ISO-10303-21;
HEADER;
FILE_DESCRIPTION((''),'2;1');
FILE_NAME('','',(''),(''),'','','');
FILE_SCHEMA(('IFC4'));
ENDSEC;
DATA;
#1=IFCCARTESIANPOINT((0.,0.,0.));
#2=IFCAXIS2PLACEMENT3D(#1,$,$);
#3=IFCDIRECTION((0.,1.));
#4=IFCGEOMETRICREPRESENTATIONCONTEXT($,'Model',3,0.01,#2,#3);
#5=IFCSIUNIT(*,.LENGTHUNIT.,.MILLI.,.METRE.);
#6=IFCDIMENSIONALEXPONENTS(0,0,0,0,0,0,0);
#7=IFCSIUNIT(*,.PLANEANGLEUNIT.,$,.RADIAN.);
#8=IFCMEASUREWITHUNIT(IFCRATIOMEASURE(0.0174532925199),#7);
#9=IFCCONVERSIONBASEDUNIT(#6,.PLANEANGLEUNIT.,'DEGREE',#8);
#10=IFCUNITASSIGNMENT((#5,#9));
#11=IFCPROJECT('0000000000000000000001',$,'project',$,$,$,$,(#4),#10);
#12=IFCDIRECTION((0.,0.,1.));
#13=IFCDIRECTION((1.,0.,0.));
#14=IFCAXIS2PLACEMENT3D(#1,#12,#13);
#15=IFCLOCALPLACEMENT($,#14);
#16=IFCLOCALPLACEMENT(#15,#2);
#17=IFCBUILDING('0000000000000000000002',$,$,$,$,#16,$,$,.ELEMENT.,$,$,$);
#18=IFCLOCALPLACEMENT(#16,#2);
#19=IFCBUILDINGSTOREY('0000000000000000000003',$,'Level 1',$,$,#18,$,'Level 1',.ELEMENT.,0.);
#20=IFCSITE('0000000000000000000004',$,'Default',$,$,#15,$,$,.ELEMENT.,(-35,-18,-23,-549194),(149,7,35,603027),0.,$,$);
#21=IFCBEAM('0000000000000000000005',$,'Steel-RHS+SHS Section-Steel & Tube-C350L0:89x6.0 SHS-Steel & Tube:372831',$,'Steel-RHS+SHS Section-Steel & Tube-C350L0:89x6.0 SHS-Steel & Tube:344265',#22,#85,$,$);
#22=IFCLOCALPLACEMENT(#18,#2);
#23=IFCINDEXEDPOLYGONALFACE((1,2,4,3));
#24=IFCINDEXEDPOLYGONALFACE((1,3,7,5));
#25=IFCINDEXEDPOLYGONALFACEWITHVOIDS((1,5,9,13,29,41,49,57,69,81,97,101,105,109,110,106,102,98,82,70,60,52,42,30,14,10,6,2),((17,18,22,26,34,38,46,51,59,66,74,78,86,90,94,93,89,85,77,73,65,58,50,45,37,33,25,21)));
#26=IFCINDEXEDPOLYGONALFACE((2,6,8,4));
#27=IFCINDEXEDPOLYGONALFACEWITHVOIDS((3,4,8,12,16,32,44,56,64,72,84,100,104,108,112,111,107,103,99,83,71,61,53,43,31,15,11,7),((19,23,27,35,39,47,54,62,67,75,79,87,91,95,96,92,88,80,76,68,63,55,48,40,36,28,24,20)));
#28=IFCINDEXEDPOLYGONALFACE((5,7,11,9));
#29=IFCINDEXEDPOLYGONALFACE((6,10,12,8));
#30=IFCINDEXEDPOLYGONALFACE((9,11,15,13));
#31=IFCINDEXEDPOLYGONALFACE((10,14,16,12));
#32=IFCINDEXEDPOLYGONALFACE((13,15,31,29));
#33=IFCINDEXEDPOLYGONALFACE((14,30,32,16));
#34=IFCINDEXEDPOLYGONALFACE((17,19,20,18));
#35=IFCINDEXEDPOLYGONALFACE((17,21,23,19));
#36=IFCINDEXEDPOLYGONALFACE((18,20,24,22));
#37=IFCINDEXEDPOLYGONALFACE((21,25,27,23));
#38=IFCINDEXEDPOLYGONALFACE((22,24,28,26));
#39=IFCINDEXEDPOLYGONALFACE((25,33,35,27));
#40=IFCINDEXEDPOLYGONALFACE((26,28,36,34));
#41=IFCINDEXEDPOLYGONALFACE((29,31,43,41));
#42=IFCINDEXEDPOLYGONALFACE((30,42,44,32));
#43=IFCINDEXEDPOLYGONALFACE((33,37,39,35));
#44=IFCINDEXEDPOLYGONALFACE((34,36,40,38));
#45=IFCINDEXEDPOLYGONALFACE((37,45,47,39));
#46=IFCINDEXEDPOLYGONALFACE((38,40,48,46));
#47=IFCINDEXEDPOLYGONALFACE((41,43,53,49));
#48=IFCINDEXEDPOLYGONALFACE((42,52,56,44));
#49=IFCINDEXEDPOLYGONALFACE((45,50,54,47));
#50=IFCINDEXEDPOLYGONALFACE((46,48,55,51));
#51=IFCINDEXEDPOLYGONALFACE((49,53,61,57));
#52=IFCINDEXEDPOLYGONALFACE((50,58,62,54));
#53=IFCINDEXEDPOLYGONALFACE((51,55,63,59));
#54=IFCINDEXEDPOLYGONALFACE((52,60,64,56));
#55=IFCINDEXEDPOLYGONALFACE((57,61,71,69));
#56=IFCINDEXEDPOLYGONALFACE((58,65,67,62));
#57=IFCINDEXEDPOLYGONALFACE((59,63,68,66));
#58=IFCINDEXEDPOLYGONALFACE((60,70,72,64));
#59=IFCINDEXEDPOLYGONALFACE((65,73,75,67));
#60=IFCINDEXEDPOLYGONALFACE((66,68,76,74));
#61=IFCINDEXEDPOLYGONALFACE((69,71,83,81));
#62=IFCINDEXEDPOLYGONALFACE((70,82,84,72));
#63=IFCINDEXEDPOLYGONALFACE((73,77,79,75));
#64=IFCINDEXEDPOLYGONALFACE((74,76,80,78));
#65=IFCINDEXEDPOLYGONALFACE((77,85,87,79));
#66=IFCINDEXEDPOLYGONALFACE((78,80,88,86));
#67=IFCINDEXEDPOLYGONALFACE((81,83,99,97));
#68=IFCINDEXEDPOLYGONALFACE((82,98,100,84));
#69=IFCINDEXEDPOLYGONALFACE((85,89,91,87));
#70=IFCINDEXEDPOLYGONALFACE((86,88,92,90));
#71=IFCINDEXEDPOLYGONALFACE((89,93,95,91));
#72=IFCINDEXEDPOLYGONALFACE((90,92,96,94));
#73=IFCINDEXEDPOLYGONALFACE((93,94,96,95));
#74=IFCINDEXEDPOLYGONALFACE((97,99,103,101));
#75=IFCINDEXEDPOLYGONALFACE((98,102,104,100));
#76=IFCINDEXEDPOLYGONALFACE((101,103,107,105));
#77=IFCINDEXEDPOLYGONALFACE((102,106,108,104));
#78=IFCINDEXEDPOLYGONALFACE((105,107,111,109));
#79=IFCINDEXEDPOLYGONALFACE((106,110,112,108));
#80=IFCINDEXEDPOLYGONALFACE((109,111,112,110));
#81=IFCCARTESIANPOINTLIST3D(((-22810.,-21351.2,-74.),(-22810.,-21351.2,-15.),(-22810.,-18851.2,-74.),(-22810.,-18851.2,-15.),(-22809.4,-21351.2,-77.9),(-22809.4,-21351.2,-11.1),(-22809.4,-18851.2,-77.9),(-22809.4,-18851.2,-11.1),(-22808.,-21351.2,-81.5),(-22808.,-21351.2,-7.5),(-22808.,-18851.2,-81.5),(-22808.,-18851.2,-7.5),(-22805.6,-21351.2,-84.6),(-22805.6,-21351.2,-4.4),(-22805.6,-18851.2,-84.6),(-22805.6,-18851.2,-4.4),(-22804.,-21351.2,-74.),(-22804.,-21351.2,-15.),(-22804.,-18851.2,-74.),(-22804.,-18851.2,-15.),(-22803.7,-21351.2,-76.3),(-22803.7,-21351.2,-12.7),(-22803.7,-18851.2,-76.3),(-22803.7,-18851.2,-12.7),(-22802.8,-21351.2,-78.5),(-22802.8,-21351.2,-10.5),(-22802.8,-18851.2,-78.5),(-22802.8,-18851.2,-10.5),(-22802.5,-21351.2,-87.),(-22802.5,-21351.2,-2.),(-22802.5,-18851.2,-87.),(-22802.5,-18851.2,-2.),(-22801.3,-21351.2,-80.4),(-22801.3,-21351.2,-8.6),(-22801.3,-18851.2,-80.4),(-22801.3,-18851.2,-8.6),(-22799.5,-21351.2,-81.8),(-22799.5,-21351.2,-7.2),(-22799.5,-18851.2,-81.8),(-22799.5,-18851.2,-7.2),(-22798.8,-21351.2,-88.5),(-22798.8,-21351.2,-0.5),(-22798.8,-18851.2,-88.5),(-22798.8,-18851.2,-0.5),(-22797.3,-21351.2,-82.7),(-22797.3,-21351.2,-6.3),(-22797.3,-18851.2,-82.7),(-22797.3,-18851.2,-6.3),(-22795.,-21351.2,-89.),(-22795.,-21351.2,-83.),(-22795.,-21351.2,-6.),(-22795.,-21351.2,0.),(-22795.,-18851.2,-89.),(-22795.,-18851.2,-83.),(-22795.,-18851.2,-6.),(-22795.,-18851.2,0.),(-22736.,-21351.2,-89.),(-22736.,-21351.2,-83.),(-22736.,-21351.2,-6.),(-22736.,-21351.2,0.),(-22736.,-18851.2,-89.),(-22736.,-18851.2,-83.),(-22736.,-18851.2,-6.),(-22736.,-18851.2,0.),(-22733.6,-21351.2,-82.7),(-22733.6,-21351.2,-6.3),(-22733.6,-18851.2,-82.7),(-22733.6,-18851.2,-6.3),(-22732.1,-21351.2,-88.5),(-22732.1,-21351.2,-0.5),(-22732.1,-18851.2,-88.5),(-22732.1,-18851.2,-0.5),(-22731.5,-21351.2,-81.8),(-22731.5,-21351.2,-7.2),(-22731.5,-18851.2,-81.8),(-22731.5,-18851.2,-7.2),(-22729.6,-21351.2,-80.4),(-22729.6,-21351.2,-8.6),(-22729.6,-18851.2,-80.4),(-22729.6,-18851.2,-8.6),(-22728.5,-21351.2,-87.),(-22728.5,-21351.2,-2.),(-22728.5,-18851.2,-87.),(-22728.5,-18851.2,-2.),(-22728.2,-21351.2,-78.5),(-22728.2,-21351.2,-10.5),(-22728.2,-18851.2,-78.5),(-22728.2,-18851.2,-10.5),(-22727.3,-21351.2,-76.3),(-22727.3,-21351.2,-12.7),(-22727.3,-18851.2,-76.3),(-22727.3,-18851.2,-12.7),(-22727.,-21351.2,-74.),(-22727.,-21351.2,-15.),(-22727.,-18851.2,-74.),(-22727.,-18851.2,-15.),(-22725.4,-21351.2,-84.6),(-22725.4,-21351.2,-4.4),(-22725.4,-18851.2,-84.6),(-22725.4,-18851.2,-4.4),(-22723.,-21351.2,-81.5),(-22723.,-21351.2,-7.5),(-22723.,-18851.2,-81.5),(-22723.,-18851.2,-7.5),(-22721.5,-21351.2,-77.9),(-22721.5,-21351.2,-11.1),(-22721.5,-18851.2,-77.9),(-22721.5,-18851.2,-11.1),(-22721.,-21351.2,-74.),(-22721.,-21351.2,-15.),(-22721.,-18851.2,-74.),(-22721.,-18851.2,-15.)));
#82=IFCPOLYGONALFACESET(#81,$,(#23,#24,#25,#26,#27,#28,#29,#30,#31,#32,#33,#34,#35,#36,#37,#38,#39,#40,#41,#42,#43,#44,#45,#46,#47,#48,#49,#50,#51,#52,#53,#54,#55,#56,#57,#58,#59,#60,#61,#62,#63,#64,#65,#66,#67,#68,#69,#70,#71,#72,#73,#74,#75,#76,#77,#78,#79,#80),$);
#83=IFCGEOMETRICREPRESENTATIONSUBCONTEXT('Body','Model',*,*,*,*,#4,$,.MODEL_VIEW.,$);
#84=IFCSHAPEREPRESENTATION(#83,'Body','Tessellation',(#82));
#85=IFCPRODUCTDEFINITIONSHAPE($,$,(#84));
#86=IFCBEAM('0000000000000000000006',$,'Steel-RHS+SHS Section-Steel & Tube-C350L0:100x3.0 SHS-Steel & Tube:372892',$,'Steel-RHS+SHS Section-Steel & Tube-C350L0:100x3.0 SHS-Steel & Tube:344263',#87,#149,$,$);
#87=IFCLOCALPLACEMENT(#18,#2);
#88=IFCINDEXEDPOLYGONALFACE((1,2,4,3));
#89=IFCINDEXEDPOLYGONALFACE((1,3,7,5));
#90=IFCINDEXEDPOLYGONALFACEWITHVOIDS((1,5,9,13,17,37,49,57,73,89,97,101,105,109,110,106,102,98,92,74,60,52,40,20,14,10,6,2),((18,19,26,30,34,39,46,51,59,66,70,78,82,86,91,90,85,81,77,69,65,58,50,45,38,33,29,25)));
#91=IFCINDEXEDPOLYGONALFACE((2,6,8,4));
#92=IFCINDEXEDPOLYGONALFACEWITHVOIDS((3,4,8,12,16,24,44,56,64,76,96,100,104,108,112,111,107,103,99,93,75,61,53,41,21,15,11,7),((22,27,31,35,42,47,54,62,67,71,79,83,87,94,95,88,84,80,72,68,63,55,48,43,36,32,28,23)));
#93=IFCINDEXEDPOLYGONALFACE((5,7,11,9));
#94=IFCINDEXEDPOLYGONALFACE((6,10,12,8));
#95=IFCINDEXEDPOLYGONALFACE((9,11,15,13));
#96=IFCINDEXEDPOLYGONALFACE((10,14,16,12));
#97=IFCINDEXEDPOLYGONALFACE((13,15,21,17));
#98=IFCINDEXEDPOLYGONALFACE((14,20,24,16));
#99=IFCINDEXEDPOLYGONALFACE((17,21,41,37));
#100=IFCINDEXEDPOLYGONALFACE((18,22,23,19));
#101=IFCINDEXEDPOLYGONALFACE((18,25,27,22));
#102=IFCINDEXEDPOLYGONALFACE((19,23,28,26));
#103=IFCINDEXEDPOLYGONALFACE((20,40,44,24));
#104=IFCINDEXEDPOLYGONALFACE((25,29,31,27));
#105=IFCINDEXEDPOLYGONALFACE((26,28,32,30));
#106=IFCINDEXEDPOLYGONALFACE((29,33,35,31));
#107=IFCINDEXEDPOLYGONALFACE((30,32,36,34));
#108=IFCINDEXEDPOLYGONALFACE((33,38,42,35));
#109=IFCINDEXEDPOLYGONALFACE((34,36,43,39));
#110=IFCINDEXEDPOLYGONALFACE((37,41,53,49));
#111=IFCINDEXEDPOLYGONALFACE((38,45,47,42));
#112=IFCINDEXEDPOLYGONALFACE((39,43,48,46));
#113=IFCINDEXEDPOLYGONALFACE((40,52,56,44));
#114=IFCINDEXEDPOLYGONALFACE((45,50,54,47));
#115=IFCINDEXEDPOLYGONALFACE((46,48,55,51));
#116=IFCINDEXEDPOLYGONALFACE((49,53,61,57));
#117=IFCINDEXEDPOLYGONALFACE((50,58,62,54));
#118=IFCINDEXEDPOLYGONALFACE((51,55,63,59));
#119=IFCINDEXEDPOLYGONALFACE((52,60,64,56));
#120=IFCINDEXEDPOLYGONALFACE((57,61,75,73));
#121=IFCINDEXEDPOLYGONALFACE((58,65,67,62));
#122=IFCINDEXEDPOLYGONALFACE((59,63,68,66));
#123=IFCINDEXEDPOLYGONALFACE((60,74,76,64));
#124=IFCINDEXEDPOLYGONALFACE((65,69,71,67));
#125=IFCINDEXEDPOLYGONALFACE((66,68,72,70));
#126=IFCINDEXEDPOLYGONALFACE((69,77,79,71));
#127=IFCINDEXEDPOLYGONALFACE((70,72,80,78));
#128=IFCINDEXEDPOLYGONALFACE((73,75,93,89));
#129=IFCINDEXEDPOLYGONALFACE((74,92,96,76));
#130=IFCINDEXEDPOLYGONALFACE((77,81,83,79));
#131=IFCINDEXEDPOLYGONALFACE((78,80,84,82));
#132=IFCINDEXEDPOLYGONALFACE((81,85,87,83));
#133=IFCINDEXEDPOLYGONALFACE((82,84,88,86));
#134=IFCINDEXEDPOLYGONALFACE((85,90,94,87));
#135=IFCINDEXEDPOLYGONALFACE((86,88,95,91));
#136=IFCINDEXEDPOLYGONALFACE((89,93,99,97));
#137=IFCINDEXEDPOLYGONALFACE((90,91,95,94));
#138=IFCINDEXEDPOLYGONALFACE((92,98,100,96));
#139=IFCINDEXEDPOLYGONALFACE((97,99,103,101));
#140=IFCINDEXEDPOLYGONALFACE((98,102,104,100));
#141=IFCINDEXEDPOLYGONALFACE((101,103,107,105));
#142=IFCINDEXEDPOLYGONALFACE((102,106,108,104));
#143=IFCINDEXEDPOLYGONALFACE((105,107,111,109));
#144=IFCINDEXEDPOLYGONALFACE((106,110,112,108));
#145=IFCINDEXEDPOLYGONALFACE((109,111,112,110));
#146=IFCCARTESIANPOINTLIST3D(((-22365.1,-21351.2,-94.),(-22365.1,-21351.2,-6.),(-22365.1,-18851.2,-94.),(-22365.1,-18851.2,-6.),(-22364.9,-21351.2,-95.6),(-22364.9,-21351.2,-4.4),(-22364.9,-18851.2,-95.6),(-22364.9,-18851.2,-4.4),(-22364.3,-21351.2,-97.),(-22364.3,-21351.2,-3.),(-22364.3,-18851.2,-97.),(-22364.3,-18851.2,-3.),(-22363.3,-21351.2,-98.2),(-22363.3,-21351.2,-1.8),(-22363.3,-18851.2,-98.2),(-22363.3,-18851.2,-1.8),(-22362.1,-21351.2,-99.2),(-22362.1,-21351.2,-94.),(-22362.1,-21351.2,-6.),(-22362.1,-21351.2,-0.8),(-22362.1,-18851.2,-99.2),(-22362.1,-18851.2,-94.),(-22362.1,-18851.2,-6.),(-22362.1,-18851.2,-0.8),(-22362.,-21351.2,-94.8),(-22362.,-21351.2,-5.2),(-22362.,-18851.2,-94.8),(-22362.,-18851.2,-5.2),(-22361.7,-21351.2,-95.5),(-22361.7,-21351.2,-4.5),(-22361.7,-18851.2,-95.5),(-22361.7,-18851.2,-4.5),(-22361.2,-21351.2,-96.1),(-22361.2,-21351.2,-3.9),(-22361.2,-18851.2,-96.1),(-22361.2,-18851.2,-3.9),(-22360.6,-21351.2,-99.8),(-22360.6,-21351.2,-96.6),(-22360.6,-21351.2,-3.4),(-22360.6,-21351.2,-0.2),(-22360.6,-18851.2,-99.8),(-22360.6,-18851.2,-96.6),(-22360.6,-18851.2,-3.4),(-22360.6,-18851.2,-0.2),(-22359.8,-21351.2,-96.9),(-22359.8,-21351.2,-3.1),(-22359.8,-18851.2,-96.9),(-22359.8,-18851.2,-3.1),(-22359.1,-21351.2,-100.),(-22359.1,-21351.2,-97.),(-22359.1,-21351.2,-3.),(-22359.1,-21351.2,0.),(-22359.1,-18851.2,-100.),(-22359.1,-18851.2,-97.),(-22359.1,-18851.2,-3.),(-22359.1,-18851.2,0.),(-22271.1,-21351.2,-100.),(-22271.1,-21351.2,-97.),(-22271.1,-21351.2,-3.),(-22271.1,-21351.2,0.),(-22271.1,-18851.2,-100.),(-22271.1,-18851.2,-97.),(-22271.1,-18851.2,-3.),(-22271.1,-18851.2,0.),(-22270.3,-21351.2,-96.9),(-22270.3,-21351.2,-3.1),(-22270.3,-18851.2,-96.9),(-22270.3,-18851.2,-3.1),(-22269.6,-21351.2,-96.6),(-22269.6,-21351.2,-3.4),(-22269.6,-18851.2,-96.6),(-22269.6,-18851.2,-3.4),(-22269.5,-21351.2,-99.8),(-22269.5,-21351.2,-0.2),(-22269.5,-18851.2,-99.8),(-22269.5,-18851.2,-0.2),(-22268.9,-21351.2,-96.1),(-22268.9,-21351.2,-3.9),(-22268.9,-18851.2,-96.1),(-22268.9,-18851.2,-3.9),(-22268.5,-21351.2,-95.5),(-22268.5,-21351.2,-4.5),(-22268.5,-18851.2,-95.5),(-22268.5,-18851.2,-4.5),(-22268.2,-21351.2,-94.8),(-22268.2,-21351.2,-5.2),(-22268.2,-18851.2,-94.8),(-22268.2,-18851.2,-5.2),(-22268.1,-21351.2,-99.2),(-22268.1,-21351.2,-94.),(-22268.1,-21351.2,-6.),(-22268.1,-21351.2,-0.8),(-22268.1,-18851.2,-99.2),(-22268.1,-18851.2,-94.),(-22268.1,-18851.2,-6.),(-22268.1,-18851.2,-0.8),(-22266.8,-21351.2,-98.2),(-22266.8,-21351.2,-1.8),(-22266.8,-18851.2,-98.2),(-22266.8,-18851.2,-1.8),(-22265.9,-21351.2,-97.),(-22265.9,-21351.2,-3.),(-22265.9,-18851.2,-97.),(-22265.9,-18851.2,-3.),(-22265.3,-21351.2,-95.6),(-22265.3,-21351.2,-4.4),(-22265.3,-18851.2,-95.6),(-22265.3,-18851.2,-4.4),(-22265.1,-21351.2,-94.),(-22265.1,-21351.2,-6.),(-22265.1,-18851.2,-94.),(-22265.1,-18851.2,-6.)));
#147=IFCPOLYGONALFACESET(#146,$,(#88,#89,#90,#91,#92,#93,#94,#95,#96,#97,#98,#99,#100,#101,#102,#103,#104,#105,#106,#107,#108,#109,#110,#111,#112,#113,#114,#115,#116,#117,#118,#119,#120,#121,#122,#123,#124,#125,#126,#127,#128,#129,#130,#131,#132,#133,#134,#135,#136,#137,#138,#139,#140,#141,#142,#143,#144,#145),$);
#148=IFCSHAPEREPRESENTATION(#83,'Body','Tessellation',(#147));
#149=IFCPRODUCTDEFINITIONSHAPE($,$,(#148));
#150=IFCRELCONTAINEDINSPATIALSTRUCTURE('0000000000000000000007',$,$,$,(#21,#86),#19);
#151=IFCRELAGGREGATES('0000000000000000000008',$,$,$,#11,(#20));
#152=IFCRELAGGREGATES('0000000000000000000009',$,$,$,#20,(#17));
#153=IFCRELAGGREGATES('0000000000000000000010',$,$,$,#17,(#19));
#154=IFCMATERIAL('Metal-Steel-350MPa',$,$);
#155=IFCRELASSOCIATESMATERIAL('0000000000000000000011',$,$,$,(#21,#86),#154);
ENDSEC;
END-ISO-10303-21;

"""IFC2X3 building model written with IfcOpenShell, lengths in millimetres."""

from ifc_helpers import new_model, entity, si_unit, converted_unit, direction, frame, frame_2d, origin, origin_with_axes, place, context, subcontext, project, spatial, polyline, circle_curve, parameter, trimmed, segment, composite_curve, outline, extrude, material, element, save


model = new_model("IFC2X3")

# Units and contexts
model_context = context("Model", 3, precision=0.01, world=origin(), true_north=direction((0.0, 1.0)))
body_context = subcontext(model_context, "Body", "Model", "MODEL_VIEW")
ifc_project = project(units=[si_unit("LENGTHUNIT", "METRE", prefix="MILLI"), converted_unit("PLANEANGLEUNIT", "DEGREE", entity("IfcRatioMeasure", 0.0174532925199), si_unit("PLANEANGLEUNIT", "RADIAN"), dimensions=[0, 0, 0, 0, 0, 0, 0])], contexts=[model_context])

# Site, building, storey
site_placement = place(None, origin_with_axes())
site = spatial("IfcSite", under=ifc_project, at=site_placement, Name="Default", CompositionType="ELEMENT", RefLatitude=(-35, -18, -23, -549194), RefLongitude=(149, 7, 35, 603027), RefElevation=0.0)
building_placement = place(site_placement, origin())
building = spatial("IfcBuilding", under=site, at=building_placement, CompositionType="ELEMENT")
storey_placement = place(building_placement, origin())
storey = spatial("IfcBuildingStorey", under=building, at=storey_placement, Name="Level 1", LongName="Level 1", CompositionType="ELEMENT", Elevation=0.0)

# Beams
ifc_material = material(Name="Metal-Steel-350MPa")
beam_1_placement = place(storey_placement, frame((-22765.5, -18851.2, 0.0), z_axis=(0.0, 0.0, 1.0), x_axis=(0.0, -1.0, 0.0)))
element("IfcBeam", 1, at=beam_1_placement, inside=storey, material=ifc_material, Name="Steel-RHS+SHS Section-Steel & Tube-C350L0:89x6.0 SHS-Steel & Tube:372831", ObjectType="Steel-RHS+SHS Section-Steel & Tube-C350L0:89x6.0 SHS-Steel & Tube:344265", context=body_context, shape_type="SweptSolid", body=[
    extrude(outline(composite_curve([segment(trimmed(circle_curve(frame_2d((-29.5, -29.5), x_axis=(1.0, 0.0)), 15.0), [parameter(180.0)], [parameter(270.0)], True, "PARAMETER"), True, "CONTINUOUS"), segment(polyline([(-29.5, -44.5), (29.5, -44.5)]), True, "CONTINUOUS"), segment(trimmed(circle_curve(frame_2d((29.5, -29.5), x_axis=(1.0, 0.0)), 15.0), [parameter(270.0)], [parameter(0.0)], True, "PARAMETER"), True, "CONTINUOUS"), segment(polyline([(44.5, -29.5), (44.5, 29.5)]), True, "CONTINUOUS"), segment(trimmed(circle_curve(frame_2d((29.5, 29.5), x_axis=(1.0, 0.0)), 15.0), [parameter(0.0)], [parameter(90.0)], True, "PARAMETER"), True, "CONTINUOUS"), segment(polyline([(29.5, 44.5), (-29.5, 44.5)]), True, "CONTINUOUS"), segment(trimmed(circle_curve(frame_2d((-29.5, 29.5), x_axis=(1.0, 0.0)), 15.0), [parameter(90.0)], [parameter(180.0)], True, "PARAMETER"), True, "CONTINUOUS"), segment(polyline([(-44.5, 29.5), (-44.5, -29.5)]), True, "CONTINUOUS")], self_intersect=False), holes=[composite_curve([segment(polyline([(29.5, -38.5), (-29.5, -38.5)]), True, "CONTINUOUS"), segment(trimmed(circle_curve(frame_2d((-29.5, -29.5), x_axis=(1.0, 0.0)), 9.0), [parameter(180.0)], [parameter(270.0)], True, "PARAMETER"), False, "CONTINUOUS"), segment(polyline([(-38.5, -29.5), (-38.5, 29.5)]), True, "CONTINUOUS"), segment(trimmed(circle_curve(frame_2d((-29.5, 29.5), x_axis=(1.0, 0.0)), 9.0), [parameter(90.0)], [parameter(180.0)], True, "PARAMETER"), False, "CONTINUOUS"), segment(polyline([(-29.5, 38.5), (29.5, 38.5)]), True, "CONTINUOUS"), segment(trimmed(circle_curve(frame_2d((29.5, 29.5), x_axis=(1.0, 0.0)), 9.0), [parameter(360.0)], [parameter(90.0)], True, "PARAMETER"), False, "CONTINUOUS"), segment(polyline([(38.5, 29.5), (38.5, -29.5)]), True, "CONTINUOUS"), segment(trimmed(circle_curve(frame_2d((29.5, -29.5), x_axis=(1.0, 0.0)), 9.0), [parameter(270.0)], [parameter(360.0)], True, "PARAMETER"), False, "CONTINUOUS")], self_intersect=False)]), frame((0.0, 0.0, -44.5), z_axis=(1.0, 0.0, 0.0), x_axis=(0.0, -1.0, 0.0)), (0.0, 0.0, 1.0), 2500.0),
])
beam_2_placement = place(storey_placement, frame((-22315.1, -18851.2, 0.0), z_axis=(0.0, 0.0, 1.0), x_axis=(0.0, -1.0, 0.0)))
element("IfcBeam", 2, at=beam_2_placement, inside=storey, material=ifc_material, Name="Steel-RHS+SHS Section-Steel & Tube-C350L0:100x3.0 SHS-Steel & Tube:372892", ObjectType="Steel-RHS+SHS Section-Steel & Tube-C350L0:100x3.0 SHS-Steel & Tube:344263", context=body_context, shape_type="SweptSolid", body=[
    extrude(outline(composite_curve([segment(trimmed(circle_curve(frame_2d((-44.0, -44.0), x_axis=(1.0, 0.0)), 6.0), [parameter(180.0)], [parameter(270.0)], True, "PARAMETER"), True, "CONTINUOUS"), segment(polyline([(-44.0, -50.0), (44.0, -50.0)]), True, "CONTINUOUS"), segment(trimmed(circle_curve(frame_2d((44.0, -44.0), x_axis=(1.0, 0.0)), 6.0), [parameter(270.0)], [parameter(0.0)], True, "PARAMETER"), True, "CONTINUOUS"), segment(polyline([(50.0, -44.0), (50.0, 44.0)]), True, "CONTINUOUS"), segment(trimmed(circle_curve(frame_2d((44.0, 44.0), x_axis=(1.0, 0.0)), 6.0), [parameter(0.0)], [parameter(90.0)], True, "PARAMETER"), True, "CONTINUOUS"), segment(polyline([(44.0, 50.0), (-44.0, 50.0)]), True, "CONTINUOUS"), segment(trimmed(circle_curve(frame_2d((-44.0, 44.0), x_axis=(1.0, 0.0)), 6.0), [parameter(90.0)], [parameter(180.0)], True, "PARAMETER"), True, "CONTINUOUS"), segment(polyline([(-50.0, 44.0), (-50.0, -44.0)]), True, "CONTINUOUS")], self_intersect=False), holes=[composite_curve([segment(polyline([(44.0, -47.0), (-44.0, -47.0)]), True, "CONTINUOUS"), segment(trimmed(circle_curve(frame_2d((-44.0, -44.0), x_axis=(1.0, 0.0)), 3.0), [parameter(180.0)], [parameter(270.0)], True, "PARAMETER"), False, "CONTINUOUS"), segment(polyline([(-47.0, -44.0), (-47.0, 44.0)]), True, "CONTINUOUS"), segment(trimmed(circle_curve(frame_2d((-44.0, 44.0), x_axis=(1.0, 0.0)), 3.0), [parameter(90.0)], [parameter(180.0)], True, "PARAMETER"), False, "CONTINUOUS"), segment(polyline([(-44.0, 47.0), (44.0, 47.0)]), True, "CONTINUOUS"), segment(trimmed(circle_curve(frame_2d((44.0, 44.0), x_axis=(1.0, 0.0)), 3.0), [parameter(360.0)], [parameter(90.0)], True, "PARAMETER"), False, "CONTINUOUS"), segment(polyline([(47.0, 44.0), (47.0, -44.0)]), True, "CONTINUOUS"), segment(trimmed(circle_curve(frame_2d((44.0, -44.0), x_axis=(1.0, 0.0)), 3.0), [parameter(270.0)], [parameter(0.0)], True, "PARAMETER"), False, "CONTINUOUS")], self_intersect=False)]), frame((0.0, 0.0, -50.0), z_axis=(1.0, 0.0, 0.0), x_axis=(0.0, -1.0, 0.0)), (0.0, 0.0, 1.0), 2500.0),
])

save(model, "model.ifc")
